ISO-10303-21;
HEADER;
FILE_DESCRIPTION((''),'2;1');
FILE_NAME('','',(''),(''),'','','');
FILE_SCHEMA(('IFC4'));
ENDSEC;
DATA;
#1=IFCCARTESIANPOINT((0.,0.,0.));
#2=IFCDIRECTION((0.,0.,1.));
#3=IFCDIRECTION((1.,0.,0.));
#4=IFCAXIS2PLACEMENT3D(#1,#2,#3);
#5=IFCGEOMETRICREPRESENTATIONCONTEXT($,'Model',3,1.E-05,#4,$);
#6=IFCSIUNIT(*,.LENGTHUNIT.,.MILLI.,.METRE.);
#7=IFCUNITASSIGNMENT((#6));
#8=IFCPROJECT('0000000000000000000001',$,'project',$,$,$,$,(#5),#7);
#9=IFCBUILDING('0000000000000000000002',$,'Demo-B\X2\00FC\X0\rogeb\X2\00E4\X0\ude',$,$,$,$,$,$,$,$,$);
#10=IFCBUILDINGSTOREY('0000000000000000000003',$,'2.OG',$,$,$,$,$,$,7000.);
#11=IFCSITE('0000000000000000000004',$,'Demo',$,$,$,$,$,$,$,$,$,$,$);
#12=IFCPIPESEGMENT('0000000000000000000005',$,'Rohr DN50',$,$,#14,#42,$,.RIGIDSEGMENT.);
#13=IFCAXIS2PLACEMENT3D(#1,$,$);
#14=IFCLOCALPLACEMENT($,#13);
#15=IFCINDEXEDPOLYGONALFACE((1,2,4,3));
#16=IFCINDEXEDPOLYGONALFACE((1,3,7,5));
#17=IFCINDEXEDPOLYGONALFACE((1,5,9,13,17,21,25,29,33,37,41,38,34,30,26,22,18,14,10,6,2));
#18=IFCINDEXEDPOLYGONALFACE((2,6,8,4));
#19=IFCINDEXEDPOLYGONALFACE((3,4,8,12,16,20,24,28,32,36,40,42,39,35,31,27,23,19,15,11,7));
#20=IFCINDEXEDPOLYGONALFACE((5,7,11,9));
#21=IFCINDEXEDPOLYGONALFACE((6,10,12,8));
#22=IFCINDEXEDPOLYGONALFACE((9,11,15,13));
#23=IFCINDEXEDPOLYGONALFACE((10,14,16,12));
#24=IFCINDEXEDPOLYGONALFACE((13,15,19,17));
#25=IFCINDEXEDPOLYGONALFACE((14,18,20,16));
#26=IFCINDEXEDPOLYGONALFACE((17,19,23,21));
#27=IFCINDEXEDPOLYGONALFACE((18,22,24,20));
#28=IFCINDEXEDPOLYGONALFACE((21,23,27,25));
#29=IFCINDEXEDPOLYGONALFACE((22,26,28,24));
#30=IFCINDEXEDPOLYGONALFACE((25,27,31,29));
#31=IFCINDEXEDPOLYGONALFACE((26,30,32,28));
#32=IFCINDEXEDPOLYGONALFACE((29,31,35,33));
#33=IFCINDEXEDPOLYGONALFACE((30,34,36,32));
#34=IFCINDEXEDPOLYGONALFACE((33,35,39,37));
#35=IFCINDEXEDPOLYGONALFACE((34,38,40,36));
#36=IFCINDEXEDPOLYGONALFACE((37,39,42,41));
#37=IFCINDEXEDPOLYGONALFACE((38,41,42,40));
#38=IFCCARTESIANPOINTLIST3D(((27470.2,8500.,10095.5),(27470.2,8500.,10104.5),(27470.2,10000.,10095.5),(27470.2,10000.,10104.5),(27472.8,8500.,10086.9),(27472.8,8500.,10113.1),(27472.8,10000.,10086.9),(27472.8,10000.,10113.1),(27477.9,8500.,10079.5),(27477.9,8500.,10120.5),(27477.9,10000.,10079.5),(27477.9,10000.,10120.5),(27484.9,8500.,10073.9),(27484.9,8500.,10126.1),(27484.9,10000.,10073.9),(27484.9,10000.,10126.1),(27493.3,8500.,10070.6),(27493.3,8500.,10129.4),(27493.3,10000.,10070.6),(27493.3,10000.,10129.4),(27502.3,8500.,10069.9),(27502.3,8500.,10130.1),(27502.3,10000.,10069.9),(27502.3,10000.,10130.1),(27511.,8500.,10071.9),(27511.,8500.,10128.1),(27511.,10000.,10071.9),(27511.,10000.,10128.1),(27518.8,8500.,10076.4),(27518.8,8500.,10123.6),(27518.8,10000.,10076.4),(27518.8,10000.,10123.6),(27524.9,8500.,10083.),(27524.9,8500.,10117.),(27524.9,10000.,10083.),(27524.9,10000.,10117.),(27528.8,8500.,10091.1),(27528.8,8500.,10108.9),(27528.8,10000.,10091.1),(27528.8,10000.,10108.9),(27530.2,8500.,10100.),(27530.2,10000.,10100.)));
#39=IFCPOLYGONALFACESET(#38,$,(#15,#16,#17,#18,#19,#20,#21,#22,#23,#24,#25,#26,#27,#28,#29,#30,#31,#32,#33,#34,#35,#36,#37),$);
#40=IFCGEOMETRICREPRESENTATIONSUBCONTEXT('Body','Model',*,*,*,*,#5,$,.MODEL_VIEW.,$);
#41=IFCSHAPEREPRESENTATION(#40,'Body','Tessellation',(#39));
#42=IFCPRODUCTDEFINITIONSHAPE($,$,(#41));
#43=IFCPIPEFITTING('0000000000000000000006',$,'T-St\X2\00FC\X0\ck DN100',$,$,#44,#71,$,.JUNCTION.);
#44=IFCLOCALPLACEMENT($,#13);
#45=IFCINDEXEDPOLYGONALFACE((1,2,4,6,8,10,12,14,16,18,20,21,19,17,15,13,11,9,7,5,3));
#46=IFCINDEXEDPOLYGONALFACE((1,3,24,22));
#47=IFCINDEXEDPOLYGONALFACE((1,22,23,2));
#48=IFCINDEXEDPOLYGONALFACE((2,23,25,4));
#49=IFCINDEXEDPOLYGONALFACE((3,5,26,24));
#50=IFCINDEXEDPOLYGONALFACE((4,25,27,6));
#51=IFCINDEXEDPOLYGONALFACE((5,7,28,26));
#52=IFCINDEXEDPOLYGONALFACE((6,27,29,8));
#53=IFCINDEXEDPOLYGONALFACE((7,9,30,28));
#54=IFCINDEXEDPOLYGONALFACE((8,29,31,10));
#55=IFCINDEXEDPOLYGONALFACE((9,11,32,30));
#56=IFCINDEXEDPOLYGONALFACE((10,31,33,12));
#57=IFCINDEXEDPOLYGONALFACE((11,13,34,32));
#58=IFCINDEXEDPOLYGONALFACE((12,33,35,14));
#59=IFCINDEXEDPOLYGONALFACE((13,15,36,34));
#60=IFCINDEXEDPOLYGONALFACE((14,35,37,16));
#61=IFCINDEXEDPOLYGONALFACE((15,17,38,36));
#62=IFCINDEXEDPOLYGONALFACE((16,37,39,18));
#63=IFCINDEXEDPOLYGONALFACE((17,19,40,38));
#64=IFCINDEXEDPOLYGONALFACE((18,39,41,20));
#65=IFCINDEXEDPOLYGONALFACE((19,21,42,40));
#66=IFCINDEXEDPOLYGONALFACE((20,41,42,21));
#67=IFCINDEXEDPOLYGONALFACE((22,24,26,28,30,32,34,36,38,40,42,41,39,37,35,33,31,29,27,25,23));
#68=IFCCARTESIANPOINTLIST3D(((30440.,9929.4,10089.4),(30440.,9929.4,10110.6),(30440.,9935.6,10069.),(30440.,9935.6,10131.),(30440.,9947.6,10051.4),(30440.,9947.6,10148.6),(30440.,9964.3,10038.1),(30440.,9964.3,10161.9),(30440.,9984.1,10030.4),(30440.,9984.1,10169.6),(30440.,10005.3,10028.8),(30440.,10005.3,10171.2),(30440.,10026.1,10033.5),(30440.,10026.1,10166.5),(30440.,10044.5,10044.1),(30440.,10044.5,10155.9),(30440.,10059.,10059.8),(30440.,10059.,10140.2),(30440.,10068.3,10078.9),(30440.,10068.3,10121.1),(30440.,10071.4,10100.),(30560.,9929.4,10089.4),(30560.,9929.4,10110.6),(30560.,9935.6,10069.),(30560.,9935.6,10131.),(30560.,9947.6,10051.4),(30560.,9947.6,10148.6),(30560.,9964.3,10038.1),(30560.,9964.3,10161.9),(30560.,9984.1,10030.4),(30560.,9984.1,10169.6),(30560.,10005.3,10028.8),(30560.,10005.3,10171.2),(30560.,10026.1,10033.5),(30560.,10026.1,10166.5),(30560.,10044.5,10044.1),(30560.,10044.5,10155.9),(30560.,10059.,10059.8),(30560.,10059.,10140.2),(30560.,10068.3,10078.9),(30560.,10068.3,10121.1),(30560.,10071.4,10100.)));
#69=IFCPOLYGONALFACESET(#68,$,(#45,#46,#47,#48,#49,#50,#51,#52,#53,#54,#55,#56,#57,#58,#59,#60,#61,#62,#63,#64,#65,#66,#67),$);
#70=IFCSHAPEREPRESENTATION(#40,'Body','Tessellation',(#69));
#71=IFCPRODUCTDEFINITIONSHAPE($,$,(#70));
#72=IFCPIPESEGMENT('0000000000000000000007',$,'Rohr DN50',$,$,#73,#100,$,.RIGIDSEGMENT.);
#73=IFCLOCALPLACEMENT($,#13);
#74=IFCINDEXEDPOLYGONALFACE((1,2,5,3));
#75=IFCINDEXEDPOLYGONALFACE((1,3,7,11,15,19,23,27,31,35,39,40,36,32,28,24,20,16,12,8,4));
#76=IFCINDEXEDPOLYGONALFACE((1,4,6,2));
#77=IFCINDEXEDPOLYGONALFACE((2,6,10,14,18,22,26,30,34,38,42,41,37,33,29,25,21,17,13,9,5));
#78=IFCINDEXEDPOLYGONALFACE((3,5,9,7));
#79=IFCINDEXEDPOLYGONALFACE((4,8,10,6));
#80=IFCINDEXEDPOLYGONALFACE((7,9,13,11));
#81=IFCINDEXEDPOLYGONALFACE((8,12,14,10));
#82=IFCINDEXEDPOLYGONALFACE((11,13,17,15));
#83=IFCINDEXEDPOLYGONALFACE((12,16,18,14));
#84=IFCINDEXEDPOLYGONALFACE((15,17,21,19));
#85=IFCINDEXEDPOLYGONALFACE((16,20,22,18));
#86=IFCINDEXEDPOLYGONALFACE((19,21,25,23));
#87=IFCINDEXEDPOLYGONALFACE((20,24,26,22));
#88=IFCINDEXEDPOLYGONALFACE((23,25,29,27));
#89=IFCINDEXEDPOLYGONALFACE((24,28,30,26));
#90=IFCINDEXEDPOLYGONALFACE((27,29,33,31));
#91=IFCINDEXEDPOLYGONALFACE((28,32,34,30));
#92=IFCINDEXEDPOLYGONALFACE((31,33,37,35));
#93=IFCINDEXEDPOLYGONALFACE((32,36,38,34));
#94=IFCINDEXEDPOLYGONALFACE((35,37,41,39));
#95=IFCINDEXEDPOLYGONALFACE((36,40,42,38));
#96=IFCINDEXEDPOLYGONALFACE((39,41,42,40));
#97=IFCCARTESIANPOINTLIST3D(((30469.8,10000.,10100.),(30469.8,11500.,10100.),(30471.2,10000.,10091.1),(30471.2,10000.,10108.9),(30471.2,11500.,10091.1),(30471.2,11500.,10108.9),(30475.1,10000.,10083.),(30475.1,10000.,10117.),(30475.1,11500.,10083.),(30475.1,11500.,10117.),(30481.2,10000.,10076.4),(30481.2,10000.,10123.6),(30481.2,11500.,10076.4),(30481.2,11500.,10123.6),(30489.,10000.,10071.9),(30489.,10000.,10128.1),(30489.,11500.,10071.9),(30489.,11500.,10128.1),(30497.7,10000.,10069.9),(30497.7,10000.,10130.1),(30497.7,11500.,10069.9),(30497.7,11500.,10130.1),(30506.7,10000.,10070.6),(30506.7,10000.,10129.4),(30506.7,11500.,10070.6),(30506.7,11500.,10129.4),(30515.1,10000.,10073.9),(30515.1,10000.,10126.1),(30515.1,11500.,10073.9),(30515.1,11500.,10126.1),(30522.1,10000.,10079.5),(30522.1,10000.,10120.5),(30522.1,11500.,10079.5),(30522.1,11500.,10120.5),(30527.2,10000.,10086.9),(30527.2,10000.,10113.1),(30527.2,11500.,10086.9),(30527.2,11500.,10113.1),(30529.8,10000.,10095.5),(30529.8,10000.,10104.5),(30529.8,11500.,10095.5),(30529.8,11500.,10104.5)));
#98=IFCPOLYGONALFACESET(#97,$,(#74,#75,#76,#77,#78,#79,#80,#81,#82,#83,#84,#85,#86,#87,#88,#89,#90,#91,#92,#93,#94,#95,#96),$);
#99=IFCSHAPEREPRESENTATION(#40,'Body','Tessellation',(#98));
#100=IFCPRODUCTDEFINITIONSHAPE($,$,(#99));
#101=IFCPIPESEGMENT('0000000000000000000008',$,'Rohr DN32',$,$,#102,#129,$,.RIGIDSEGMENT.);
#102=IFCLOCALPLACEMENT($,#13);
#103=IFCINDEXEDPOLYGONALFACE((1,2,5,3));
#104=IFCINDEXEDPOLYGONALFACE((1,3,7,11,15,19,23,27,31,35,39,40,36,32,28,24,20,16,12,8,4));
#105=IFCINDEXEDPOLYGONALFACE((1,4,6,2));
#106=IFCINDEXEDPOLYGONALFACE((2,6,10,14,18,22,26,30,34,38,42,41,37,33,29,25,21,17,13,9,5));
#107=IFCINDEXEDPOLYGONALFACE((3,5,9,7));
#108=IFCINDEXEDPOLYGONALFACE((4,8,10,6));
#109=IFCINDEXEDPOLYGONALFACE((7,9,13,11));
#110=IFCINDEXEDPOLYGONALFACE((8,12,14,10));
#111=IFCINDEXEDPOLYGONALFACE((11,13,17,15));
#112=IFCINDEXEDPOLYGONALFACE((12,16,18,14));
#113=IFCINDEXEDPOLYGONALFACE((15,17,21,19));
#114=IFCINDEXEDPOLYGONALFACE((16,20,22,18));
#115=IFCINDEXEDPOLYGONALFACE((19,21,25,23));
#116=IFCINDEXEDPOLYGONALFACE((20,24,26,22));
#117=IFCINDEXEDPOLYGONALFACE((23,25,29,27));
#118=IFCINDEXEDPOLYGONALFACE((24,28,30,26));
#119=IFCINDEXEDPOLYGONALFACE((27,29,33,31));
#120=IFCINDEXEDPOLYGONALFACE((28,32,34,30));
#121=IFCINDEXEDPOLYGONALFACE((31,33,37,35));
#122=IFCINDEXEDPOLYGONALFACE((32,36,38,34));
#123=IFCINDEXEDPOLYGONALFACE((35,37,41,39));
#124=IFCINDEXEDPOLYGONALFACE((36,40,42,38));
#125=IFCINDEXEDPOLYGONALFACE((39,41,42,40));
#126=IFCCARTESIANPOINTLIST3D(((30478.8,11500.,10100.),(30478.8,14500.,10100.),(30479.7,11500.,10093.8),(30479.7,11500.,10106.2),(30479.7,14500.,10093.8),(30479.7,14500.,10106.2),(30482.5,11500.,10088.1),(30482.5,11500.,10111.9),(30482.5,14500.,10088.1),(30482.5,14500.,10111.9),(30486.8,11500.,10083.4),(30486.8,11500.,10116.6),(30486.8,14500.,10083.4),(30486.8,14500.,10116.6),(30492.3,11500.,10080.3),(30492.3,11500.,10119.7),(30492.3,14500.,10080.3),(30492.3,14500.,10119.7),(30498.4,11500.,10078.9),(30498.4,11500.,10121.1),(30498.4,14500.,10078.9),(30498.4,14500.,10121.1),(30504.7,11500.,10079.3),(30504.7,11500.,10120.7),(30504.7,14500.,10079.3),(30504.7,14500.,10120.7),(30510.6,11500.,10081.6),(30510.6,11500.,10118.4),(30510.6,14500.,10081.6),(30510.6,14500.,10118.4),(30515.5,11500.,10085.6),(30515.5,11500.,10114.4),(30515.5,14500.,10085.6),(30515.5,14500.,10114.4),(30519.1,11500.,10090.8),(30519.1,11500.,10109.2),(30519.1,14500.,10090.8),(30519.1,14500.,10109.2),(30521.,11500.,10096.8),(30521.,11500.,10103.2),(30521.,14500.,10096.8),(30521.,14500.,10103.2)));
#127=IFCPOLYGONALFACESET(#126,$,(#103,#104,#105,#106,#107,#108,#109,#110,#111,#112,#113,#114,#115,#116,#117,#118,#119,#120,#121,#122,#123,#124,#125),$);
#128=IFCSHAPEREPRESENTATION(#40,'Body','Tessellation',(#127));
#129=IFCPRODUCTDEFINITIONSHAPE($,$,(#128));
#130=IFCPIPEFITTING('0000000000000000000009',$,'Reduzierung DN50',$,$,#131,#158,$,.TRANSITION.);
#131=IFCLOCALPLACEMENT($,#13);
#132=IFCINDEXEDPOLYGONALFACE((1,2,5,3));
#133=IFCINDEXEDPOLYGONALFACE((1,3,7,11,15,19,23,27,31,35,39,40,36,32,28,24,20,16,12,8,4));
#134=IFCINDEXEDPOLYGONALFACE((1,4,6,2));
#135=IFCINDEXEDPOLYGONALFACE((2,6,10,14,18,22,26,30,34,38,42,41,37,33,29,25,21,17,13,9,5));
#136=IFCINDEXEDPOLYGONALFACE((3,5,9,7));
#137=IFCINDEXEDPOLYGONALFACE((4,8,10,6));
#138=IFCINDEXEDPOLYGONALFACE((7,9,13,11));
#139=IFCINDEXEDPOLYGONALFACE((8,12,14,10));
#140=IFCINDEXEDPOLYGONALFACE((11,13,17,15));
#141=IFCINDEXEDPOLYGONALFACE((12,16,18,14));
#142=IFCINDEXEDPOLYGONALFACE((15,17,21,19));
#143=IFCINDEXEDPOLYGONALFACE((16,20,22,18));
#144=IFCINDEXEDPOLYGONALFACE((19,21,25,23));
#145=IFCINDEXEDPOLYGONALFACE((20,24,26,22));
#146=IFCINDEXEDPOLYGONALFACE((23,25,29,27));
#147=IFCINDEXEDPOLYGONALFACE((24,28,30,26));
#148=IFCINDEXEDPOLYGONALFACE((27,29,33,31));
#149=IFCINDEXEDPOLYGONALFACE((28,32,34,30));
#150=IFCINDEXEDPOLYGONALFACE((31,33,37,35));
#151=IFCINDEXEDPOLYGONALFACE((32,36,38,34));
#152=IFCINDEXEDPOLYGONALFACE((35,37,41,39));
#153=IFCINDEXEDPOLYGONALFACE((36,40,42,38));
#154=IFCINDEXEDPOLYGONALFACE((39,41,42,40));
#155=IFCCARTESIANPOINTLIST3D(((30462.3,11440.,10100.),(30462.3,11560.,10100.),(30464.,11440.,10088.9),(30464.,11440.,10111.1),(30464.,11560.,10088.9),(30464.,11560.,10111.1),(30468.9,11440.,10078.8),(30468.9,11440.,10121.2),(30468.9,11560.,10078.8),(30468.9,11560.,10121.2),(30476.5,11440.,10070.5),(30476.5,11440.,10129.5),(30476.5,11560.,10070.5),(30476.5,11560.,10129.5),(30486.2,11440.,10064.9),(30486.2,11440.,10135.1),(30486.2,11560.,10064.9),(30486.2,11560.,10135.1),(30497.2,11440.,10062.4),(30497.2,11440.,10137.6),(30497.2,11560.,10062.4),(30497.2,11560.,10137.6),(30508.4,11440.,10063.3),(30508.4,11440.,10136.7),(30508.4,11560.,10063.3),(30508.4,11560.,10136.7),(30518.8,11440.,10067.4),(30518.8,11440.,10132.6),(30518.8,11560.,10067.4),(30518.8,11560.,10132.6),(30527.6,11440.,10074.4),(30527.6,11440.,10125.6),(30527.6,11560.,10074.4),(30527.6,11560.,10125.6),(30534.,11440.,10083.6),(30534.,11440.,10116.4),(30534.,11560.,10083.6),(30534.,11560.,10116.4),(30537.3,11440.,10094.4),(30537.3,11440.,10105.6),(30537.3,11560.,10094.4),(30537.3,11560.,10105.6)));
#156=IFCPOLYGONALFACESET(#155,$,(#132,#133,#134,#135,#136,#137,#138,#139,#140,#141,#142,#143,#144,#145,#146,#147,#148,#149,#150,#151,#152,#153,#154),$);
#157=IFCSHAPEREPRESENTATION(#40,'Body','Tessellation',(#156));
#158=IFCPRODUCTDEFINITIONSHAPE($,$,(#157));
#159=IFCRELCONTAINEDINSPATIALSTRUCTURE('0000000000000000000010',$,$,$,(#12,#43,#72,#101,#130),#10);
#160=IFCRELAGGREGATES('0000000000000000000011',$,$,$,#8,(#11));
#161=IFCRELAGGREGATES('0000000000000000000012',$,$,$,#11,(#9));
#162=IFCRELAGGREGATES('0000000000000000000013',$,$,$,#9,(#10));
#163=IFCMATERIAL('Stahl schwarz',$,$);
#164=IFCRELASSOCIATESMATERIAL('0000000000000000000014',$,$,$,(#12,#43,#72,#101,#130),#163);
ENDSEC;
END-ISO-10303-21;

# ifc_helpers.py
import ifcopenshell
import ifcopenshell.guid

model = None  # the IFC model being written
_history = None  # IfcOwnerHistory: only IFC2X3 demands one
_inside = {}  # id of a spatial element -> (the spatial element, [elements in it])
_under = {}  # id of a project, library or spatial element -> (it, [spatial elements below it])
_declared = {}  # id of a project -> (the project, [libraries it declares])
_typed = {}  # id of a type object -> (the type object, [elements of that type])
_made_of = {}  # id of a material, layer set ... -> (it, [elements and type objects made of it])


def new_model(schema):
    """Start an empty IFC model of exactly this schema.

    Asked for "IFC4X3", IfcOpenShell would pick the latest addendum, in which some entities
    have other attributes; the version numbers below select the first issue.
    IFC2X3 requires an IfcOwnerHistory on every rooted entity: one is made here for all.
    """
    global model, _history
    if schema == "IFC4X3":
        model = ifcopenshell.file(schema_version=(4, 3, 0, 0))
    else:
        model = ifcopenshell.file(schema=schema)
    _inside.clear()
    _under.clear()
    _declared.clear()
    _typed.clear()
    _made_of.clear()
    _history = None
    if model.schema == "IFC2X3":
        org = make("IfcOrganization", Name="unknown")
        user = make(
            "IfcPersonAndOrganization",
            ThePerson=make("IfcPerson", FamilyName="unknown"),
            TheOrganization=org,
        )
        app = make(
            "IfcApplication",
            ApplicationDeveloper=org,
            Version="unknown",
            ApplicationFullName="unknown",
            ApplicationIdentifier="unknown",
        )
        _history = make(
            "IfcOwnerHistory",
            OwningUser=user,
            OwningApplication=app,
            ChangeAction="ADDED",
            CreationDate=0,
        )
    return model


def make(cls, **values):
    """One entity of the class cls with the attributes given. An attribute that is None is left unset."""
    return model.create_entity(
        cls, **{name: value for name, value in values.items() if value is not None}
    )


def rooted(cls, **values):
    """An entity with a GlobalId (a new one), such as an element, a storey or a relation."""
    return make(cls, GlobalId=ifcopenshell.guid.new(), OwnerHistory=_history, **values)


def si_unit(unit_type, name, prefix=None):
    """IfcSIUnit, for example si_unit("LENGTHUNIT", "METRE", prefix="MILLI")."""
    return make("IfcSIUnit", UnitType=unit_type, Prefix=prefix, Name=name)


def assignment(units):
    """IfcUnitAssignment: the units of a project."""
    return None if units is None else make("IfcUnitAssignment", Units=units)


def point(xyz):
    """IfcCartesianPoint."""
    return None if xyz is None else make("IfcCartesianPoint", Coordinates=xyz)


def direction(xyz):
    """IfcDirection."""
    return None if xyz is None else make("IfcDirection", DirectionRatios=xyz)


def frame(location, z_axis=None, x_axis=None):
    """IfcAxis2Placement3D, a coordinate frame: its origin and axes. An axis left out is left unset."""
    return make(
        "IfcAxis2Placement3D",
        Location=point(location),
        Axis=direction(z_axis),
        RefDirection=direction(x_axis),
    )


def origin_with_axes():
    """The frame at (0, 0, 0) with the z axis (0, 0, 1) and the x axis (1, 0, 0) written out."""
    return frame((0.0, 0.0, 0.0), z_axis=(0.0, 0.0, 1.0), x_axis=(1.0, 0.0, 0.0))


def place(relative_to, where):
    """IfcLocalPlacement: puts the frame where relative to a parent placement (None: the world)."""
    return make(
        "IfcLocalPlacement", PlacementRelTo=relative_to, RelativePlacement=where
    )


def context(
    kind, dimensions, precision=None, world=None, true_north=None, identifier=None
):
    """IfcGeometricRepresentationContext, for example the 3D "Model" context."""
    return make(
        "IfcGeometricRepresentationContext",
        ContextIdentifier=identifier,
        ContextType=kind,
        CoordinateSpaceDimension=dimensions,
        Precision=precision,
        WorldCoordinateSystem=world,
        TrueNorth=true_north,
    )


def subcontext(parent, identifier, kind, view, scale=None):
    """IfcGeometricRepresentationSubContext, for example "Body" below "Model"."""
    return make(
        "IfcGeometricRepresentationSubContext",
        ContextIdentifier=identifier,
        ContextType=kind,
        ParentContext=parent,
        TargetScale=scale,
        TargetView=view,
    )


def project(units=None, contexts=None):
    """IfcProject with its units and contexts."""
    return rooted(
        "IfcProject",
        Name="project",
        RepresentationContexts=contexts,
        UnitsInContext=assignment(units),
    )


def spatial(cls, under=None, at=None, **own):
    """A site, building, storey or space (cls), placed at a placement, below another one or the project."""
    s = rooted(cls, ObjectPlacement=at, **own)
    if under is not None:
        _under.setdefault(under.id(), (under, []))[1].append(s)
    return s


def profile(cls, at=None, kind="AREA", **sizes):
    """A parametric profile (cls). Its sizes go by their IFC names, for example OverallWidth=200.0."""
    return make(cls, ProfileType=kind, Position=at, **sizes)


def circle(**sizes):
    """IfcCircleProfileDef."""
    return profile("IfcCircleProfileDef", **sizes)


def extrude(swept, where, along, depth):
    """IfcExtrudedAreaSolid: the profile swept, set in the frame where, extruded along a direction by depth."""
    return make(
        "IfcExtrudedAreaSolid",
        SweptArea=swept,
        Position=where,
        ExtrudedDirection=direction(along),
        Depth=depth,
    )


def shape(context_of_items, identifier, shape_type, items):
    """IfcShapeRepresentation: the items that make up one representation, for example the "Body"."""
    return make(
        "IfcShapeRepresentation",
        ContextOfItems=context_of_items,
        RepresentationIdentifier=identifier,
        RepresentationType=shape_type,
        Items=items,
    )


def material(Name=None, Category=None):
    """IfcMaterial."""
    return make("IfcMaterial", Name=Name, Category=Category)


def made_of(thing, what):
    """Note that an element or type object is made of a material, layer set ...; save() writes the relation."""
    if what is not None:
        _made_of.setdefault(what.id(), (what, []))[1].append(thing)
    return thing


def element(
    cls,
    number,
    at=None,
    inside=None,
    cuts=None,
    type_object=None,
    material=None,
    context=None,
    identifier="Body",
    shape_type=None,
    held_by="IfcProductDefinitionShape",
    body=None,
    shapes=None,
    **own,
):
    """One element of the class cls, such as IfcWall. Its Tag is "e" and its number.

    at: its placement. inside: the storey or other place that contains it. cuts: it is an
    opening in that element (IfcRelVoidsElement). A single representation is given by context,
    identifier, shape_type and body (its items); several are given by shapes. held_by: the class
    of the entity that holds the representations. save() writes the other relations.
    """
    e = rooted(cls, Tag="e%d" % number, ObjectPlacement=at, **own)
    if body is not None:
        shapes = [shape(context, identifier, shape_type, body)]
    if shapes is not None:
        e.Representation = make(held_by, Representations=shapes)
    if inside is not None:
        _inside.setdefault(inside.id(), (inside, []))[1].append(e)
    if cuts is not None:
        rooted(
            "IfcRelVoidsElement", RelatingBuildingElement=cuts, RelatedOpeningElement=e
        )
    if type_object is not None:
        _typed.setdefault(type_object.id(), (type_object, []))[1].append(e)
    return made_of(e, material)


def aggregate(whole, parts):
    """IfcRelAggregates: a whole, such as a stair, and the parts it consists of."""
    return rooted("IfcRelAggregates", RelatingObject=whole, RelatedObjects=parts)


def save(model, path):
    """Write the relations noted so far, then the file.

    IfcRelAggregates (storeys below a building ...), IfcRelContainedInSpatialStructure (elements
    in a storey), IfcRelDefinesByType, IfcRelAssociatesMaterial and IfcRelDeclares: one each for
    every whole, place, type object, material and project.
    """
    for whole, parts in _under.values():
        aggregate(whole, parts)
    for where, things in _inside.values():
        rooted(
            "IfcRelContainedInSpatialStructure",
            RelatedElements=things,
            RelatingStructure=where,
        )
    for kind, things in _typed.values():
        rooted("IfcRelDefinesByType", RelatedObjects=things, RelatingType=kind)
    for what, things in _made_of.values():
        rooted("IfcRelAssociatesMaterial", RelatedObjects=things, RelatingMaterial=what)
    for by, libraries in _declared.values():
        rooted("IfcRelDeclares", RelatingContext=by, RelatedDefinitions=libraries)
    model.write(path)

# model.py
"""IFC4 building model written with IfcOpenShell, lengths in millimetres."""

from ifc_helpers import new_model, si_unit, frame, origin_with_axes, place, context, subcontext, project, spatial, circle, extrude, material, element, save


model = new_model("IFC4")

# Units and contexts
model_context = context("Model", 3, precision=1e-05, world=origin_with_axes())
body_context = subcontext(model_context, "Body", "Model", "MODEL_VIEW")
ifc_project = project(units=[si_unit("LENGTHUNIT", "METRE", prefix="MILLI")], contexts=[model_context])

# Site, building, storey
site = spatial("IfcSite", under=ifc_project, Name="Demo")
building = spatial("IfcBuilding", under=site, Name="Demo-Bürogebäude")
storey = spatial("IfcBuildingStorey", under=building, Name="2.OG", Elevation=7000.0)

# Shared definitions
ifc_material_1 = material(Name="Stahl schwarz")

# Pipe segment
pipe_segment_1_placement = place(None, frame((27500.0, 10000.0, 10100.0), z_axis=(0.0, -1.0, 0.0), x_axis=(1.0, 0.0, 0.0)))
element("IfcPipeSegment", 1, at=pipe_segment_1_placement, inside=storey, material=ifc_material_1, Name="Rohr DN50", PredefinedType="RIGIDSEGMENT", context=body_context, shape_type="SweptSolid", body=[
    extrude(circle(Radius=30.1), origin_with_axes(), (0.0, 0.0, 1.0), 1500.0),
])

# Pipe fitting
pipe_fitting_1_placement = place(None, frame((30440.0, 10000.0, 10100.0), z_axis=(1.0, 0.0, 0.0), x_axis=(0.0, 1.0, 0.0)))
element("IfcPipeFitting", 2, at=pipe_fitting_1_placement, inside=storey, material=ifc_material_1, Name="T-Stück DN100", PredefinedType="JUNCTION", context=body_context, shape_type="SweptSolid", body=[
    extrude(circle(Radius=71.4), origin_with_axes(), (0.0, 0.0, 1.0), 120.0),
])

# Pipe segments
pipe_segment_2_placement = place(None, frame((30500.0, 10000.0, 10100.0), z_axis=(0.0, 1.0, 0.0), x_axis=(-1.0, 0.0, 0.0)))
element("IfcPipeSegment", 3, at=pipe_segment_2_placement, inside=storey, material=ifc_material_1, Name="Rohr DN50", PredefinedType="RIGIDSEGMENT", context=body_context, shape_type="SweptSolid", body=[
    extrude(circle(Radius=30.1), origin_with_axes(), (0.0, 0.0, 1.0), 1500.0),
])
pipe_segment_3_placement = place(None, frame((30500.0, 11500.0, 10100.0), z_axis=(0.0, 1.0, 0.0), x_axis=(-1.0, 0.0, 0.0)))
element("IfcPipeSegment", 4, at=pipe_segment_3_placement, inside=storey, material=ifc_material_1, Name="Rohr DN32", PredefinedType="RIGIDSEGMENT", context=body_context, shape_type="SweptSolid", body=[
    extrude(circle(Radius=21.2), origin_with_axes(), (0.0, 0.0, 1.0), 3000.0),
])

# Pipe fitting
pipe_fitting_2_placement = place(None, frame((30500.0, 11440.0, 10100.0), z_axis=(0.0, 1.0, 0.0), x_axis=(-1.0, 0.0, 0.0)))
element("IfcPipeFitting", 5, at=pipe_fitting_2_placement, inside=storey, material=ifc_material_1, Name="Reduzierung DN50", PredefinedType="TRANSITION", context=body_context, shape_type="SweptSolid", body=[
    extrude(circle(Radius=37.7), origin_with_axes(), (0.0, 0.0, 1.0), 120.0),
])

save(model, "model.ifc")
